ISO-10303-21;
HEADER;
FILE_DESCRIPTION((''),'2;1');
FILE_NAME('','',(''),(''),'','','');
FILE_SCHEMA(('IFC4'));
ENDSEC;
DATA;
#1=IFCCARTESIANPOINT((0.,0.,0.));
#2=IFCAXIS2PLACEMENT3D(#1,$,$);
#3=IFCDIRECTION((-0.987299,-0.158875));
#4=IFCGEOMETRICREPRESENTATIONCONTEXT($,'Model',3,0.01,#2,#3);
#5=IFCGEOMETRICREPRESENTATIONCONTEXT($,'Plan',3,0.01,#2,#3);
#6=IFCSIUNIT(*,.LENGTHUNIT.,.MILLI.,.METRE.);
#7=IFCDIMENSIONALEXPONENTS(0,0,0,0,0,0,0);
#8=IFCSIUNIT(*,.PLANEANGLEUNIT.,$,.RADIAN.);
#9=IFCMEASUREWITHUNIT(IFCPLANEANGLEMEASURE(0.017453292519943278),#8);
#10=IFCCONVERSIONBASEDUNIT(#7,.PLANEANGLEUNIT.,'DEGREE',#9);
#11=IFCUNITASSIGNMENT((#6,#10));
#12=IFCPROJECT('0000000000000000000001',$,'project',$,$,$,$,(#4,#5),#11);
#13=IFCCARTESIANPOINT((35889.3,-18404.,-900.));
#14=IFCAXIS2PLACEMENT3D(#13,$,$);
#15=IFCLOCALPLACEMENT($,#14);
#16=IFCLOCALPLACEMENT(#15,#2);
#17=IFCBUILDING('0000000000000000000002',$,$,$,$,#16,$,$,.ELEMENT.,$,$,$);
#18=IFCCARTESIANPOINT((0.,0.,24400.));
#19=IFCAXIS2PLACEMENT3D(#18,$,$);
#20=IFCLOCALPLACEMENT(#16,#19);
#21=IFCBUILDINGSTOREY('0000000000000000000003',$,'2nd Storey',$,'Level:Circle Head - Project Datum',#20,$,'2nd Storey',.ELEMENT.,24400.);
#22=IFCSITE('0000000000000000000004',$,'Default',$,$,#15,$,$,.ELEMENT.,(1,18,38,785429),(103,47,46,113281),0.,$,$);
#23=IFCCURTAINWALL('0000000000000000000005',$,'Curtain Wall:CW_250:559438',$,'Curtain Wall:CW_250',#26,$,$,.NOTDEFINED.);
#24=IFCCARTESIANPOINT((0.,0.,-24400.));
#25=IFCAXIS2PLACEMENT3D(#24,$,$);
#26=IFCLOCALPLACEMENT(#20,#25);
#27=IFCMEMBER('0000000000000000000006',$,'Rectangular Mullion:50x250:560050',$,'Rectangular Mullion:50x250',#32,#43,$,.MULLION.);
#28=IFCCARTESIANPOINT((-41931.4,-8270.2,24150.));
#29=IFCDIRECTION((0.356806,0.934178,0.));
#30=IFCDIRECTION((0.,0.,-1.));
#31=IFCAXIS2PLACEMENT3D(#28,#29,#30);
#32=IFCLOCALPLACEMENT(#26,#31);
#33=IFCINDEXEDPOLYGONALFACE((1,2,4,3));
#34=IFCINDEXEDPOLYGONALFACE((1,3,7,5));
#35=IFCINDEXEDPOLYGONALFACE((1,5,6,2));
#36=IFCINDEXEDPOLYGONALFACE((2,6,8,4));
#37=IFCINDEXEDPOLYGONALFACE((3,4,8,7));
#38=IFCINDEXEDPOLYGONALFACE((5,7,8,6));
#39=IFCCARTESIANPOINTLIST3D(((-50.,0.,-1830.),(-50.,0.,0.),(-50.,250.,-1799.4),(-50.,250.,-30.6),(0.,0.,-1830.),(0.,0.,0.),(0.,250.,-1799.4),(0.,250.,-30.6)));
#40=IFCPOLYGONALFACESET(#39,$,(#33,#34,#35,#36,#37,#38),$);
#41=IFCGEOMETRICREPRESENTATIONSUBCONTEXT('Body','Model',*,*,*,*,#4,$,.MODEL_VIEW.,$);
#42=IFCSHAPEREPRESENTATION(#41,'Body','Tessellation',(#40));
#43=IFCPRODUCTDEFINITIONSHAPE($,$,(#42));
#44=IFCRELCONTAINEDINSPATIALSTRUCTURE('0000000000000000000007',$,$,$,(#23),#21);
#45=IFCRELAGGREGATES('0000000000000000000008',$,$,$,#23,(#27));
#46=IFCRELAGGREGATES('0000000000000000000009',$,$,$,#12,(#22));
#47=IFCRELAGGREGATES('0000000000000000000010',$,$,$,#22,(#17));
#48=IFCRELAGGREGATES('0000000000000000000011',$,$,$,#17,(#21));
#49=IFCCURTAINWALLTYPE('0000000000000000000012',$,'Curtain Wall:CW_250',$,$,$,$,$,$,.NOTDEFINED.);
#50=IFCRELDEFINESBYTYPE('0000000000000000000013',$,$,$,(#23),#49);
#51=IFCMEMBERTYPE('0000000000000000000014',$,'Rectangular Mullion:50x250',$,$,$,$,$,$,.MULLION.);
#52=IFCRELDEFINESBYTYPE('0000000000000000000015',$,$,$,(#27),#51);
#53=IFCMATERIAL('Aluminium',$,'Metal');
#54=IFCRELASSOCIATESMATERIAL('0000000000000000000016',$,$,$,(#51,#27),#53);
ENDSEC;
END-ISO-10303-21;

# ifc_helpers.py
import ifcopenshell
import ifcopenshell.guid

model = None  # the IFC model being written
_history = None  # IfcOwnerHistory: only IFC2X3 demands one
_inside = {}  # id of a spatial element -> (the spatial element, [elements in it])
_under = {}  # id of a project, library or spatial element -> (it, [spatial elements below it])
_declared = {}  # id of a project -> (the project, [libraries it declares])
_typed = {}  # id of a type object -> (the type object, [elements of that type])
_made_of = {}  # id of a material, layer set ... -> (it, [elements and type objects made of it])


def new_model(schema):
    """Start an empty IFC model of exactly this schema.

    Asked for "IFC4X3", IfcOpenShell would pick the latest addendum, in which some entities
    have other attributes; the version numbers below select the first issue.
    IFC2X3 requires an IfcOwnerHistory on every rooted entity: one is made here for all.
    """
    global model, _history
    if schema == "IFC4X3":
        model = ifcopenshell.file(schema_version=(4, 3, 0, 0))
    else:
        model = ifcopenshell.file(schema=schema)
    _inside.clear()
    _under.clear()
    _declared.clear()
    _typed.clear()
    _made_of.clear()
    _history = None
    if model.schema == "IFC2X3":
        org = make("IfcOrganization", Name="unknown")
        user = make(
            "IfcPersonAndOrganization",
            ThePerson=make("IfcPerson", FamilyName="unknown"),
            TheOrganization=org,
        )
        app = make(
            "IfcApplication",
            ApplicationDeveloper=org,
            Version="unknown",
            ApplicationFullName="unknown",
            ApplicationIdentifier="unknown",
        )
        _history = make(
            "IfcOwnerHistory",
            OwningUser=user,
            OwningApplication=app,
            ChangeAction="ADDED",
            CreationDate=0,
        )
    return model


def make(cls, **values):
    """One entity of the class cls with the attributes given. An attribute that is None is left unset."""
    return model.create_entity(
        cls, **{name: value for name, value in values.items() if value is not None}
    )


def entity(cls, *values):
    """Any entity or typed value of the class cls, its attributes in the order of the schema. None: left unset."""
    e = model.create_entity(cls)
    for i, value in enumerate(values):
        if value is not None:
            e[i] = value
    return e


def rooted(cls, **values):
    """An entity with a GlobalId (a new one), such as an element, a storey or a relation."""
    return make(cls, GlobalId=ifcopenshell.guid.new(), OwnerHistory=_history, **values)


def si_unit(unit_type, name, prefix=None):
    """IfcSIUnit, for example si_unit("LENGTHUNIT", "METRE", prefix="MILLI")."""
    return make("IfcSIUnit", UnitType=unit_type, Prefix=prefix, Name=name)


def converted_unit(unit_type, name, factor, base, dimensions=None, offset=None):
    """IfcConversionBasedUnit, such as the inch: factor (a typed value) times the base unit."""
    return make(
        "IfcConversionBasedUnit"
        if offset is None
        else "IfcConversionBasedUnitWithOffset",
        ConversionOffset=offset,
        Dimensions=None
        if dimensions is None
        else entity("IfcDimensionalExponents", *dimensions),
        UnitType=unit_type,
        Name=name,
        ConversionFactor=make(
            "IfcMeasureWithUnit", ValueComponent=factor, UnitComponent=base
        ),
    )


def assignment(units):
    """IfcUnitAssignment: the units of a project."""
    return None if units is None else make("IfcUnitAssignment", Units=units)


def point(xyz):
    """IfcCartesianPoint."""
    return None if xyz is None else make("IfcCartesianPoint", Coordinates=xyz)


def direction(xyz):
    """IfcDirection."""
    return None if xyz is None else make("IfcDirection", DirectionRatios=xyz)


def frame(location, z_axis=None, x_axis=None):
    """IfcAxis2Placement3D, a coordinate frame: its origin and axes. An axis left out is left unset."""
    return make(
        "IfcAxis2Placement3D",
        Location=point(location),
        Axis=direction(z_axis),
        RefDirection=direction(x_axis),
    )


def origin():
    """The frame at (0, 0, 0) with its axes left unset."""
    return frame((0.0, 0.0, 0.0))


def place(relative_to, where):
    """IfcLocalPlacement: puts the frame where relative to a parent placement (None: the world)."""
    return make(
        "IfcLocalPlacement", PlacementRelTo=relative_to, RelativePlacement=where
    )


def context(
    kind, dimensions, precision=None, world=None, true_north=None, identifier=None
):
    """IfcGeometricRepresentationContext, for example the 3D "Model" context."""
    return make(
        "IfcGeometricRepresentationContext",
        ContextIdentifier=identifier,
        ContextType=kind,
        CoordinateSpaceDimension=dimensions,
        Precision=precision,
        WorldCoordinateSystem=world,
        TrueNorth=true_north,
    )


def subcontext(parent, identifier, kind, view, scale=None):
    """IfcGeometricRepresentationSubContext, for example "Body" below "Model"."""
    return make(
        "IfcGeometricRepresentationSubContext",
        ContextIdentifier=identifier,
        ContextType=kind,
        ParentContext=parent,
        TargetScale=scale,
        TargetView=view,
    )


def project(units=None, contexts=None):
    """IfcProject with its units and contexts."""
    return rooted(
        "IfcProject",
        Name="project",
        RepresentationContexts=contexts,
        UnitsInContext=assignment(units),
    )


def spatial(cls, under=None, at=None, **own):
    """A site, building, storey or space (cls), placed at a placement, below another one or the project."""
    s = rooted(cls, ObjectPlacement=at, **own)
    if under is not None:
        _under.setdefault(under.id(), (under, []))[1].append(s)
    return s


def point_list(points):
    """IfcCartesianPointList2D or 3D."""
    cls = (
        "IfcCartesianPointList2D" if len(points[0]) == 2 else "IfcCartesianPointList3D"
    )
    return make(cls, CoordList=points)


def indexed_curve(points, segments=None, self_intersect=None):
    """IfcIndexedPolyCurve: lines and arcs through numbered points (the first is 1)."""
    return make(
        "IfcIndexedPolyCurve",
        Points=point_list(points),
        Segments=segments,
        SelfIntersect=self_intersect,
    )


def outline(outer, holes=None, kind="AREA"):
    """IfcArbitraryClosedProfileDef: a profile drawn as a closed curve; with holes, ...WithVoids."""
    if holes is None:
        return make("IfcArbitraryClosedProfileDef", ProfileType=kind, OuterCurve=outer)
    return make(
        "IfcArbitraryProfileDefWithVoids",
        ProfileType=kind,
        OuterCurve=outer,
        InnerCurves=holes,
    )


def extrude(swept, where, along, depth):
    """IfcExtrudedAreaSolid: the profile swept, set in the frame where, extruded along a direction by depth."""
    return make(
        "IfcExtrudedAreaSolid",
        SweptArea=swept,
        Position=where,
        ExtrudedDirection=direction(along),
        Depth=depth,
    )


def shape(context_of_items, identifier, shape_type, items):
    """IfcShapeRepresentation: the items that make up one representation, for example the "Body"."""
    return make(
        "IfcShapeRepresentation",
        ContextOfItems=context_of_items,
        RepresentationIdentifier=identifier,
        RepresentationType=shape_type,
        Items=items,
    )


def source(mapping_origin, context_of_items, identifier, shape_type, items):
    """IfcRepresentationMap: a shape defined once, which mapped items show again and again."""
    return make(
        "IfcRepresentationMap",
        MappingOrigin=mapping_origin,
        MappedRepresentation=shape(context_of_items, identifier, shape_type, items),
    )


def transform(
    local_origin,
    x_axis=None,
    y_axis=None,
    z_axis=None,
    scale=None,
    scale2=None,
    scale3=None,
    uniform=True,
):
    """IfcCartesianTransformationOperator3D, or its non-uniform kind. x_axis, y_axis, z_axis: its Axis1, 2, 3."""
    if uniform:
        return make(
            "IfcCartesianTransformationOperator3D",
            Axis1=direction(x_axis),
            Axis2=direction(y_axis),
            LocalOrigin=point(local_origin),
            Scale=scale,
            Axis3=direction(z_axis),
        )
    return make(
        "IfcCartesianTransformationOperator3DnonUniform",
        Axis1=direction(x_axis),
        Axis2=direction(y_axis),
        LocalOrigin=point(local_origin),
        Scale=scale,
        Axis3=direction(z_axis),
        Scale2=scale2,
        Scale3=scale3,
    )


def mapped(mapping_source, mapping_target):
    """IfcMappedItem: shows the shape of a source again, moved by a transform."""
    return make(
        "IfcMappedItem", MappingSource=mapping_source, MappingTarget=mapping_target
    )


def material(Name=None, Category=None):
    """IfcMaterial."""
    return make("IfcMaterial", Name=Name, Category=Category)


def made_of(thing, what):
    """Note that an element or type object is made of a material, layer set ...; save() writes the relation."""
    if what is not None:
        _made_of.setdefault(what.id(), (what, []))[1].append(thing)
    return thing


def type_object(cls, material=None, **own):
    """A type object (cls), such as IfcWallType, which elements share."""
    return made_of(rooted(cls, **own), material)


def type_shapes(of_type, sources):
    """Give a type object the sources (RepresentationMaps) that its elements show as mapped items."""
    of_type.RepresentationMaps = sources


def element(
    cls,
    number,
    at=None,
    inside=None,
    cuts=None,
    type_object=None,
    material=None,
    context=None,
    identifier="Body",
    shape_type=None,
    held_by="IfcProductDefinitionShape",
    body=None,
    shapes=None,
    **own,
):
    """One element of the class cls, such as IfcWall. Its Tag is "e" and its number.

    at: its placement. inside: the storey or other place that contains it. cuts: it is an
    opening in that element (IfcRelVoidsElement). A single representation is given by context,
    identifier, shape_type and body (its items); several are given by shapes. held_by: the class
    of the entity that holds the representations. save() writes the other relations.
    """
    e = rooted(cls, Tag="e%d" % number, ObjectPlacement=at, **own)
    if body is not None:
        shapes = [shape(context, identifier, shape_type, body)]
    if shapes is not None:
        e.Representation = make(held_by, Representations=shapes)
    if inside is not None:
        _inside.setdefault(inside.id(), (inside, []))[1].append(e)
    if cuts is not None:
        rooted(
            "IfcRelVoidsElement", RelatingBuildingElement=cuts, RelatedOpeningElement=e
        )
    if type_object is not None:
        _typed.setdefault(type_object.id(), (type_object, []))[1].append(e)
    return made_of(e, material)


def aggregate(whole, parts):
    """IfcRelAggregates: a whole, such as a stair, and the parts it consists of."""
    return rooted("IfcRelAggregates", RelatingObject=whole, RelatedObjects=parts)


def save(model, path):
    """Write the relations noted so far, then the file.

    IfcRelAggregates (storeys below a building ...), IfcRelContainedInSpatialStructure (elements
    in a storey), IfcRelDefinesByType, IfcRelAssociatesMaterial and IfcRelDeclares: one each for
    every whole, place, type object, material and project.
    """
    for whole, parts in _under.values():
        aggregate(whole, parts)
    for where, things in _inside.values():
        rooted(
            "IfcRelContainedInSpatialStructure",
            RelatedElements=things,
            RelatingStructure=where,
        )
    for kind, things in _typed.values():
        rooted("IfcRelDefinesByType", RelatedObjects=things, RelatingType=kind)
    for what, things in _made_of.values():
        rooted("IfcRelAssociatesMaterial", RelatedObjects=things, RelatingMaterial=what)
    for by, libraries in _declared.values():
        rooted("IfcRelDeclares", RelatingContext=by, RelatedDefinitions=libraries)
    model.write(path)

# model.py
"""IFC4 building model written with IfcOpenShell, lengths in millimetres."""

from ifc_helpers import new_model, entity, si_unit, converted_unit, direction, frame, origin, place, context, subcontext, project, spatial, indexed_curve, outline, extrude, source, transform, mapped, material, type_object, type_shapes, element, aggregate, save


model = new_model("IFC4")

# Units and contexts
model_context = context("Model", 3, precision=0.01, world=origin(), true_north=direction((-0.987299, -0.158875)))
plan_context = context("Plan", 3, precision=0.01, world=origin(), true_north=direction((-0.987299, -0.158875)))
body_context = subcontext(model_context, "Body", "Model", "MODEL_VIEW")
ifc_project = project(units=[si_unit("LENGTHUNIT", "METRE", prefix="MILLI"), converted_unit("PLANEANGLEUNIT", "DEGREE", entity("IfcPlaneAngleMeasure", 0.017453292519943278), si_unit("PLANEANGLEUNIT", "RADIAN"), dimensions=[0, 0, 0, 0, 0, 0, 0])], contexts=[model_context, plan_context])

# Site, building, storey
site_placement = place(None, frame((35889.3, -18404.0, -900.0)))
site = spatial("IfcSite", under=ifc_project, at=site_placement, Name="Default", CompositionType="ELEMENT", RefLatitude=(1, 18, 38, 785429), RefLongitude=(103, 47, 46, 113281), RefElevation=0.0)
building_placement = place(site_placement, origin())
building = spatial("IfcBuilding", under=site, at=building_placement, CompositionType="ELEMENT")
storey_placement = place(building_placement, frame((0.0, 0.0, 24400.0)))
storey = spatial("IfcBuildingStorey", under=building, at=storey_placement, Name="2nd Storey", ObjectType="Level:Circle Head - Project Datum", LongName="2nd Storey", CompositionType="ELEMENT", Elevation=24400.0)

# Shared definitions
curtain_wall_type = type_object("IfcCurtainWallType", Name="Curtain Wall:CW_250", PredefinedType="NOTDEFINED")
ifc_material_1 = material(Name="Aluminium", Category="Metal")

# Curtain wall, member
curtain_wall_1_placement = place(storey_placement, frame((0.0, 0.0, -24400.0)))
curtain_wall_1 = element("IfcCurtainWall", 1, at=curtain_wall_1_placement, inside=storey, type_object=curtain_wall_type, Name="Curtain Wall:CW_250:559438", ObjectType="Curtain Wall:CW_250", PredefinedType="NOTDEFINED")
member_type_1 = type_object("IfcMemberType", Name="Rectangular Mullion:50x250", PredefinedType="MULLION", material=ifc_material_1)
shared_shape_1 = source(origin(), body_context, "Body", "SweptSolid", [
    extrude(outline(indexed_curve([(-915.0, -125.0), (915.0, -125.0), (884.4, 125.0), (-884.4, 125.0), (-915.0, -125.0)], self_intersect=False)), frame((-50.0, 125.0, -915.0), z_axis=(1.0, 0.0, 0.0), x_axis=(0.0, 0.0, -1.0)), (0.0, 0.0, 1.0), 50.0),
])
type_shapes(member_type_1, [shared_shape_1])
member_1_placement = place(curtain_wall_1_placement, frame((-41931.4, -8270.2, 24150.0), z_axis=(0.356806, 0.934178, 0.0), x_axis=(0.0, 0.0, -1.0)))
member_1 = element("IfcMember", 2, at=member_1_placement, type_object=member_type_1, material=ifc_material_1, Name="Rectangular Mullion:50x250:560050", ObjectType="Rectangular Mullion:50x250", PredefinedType="MULLION", context=body_context, shape_type="MappedRepresentation", body=[
    mapped(shared_shape_1, transform((0.0, 0.0, 0.0), scale=1.0)),
])

aggregate(curtain_wall_1, [member_1])

save(model, "model.ifc")
